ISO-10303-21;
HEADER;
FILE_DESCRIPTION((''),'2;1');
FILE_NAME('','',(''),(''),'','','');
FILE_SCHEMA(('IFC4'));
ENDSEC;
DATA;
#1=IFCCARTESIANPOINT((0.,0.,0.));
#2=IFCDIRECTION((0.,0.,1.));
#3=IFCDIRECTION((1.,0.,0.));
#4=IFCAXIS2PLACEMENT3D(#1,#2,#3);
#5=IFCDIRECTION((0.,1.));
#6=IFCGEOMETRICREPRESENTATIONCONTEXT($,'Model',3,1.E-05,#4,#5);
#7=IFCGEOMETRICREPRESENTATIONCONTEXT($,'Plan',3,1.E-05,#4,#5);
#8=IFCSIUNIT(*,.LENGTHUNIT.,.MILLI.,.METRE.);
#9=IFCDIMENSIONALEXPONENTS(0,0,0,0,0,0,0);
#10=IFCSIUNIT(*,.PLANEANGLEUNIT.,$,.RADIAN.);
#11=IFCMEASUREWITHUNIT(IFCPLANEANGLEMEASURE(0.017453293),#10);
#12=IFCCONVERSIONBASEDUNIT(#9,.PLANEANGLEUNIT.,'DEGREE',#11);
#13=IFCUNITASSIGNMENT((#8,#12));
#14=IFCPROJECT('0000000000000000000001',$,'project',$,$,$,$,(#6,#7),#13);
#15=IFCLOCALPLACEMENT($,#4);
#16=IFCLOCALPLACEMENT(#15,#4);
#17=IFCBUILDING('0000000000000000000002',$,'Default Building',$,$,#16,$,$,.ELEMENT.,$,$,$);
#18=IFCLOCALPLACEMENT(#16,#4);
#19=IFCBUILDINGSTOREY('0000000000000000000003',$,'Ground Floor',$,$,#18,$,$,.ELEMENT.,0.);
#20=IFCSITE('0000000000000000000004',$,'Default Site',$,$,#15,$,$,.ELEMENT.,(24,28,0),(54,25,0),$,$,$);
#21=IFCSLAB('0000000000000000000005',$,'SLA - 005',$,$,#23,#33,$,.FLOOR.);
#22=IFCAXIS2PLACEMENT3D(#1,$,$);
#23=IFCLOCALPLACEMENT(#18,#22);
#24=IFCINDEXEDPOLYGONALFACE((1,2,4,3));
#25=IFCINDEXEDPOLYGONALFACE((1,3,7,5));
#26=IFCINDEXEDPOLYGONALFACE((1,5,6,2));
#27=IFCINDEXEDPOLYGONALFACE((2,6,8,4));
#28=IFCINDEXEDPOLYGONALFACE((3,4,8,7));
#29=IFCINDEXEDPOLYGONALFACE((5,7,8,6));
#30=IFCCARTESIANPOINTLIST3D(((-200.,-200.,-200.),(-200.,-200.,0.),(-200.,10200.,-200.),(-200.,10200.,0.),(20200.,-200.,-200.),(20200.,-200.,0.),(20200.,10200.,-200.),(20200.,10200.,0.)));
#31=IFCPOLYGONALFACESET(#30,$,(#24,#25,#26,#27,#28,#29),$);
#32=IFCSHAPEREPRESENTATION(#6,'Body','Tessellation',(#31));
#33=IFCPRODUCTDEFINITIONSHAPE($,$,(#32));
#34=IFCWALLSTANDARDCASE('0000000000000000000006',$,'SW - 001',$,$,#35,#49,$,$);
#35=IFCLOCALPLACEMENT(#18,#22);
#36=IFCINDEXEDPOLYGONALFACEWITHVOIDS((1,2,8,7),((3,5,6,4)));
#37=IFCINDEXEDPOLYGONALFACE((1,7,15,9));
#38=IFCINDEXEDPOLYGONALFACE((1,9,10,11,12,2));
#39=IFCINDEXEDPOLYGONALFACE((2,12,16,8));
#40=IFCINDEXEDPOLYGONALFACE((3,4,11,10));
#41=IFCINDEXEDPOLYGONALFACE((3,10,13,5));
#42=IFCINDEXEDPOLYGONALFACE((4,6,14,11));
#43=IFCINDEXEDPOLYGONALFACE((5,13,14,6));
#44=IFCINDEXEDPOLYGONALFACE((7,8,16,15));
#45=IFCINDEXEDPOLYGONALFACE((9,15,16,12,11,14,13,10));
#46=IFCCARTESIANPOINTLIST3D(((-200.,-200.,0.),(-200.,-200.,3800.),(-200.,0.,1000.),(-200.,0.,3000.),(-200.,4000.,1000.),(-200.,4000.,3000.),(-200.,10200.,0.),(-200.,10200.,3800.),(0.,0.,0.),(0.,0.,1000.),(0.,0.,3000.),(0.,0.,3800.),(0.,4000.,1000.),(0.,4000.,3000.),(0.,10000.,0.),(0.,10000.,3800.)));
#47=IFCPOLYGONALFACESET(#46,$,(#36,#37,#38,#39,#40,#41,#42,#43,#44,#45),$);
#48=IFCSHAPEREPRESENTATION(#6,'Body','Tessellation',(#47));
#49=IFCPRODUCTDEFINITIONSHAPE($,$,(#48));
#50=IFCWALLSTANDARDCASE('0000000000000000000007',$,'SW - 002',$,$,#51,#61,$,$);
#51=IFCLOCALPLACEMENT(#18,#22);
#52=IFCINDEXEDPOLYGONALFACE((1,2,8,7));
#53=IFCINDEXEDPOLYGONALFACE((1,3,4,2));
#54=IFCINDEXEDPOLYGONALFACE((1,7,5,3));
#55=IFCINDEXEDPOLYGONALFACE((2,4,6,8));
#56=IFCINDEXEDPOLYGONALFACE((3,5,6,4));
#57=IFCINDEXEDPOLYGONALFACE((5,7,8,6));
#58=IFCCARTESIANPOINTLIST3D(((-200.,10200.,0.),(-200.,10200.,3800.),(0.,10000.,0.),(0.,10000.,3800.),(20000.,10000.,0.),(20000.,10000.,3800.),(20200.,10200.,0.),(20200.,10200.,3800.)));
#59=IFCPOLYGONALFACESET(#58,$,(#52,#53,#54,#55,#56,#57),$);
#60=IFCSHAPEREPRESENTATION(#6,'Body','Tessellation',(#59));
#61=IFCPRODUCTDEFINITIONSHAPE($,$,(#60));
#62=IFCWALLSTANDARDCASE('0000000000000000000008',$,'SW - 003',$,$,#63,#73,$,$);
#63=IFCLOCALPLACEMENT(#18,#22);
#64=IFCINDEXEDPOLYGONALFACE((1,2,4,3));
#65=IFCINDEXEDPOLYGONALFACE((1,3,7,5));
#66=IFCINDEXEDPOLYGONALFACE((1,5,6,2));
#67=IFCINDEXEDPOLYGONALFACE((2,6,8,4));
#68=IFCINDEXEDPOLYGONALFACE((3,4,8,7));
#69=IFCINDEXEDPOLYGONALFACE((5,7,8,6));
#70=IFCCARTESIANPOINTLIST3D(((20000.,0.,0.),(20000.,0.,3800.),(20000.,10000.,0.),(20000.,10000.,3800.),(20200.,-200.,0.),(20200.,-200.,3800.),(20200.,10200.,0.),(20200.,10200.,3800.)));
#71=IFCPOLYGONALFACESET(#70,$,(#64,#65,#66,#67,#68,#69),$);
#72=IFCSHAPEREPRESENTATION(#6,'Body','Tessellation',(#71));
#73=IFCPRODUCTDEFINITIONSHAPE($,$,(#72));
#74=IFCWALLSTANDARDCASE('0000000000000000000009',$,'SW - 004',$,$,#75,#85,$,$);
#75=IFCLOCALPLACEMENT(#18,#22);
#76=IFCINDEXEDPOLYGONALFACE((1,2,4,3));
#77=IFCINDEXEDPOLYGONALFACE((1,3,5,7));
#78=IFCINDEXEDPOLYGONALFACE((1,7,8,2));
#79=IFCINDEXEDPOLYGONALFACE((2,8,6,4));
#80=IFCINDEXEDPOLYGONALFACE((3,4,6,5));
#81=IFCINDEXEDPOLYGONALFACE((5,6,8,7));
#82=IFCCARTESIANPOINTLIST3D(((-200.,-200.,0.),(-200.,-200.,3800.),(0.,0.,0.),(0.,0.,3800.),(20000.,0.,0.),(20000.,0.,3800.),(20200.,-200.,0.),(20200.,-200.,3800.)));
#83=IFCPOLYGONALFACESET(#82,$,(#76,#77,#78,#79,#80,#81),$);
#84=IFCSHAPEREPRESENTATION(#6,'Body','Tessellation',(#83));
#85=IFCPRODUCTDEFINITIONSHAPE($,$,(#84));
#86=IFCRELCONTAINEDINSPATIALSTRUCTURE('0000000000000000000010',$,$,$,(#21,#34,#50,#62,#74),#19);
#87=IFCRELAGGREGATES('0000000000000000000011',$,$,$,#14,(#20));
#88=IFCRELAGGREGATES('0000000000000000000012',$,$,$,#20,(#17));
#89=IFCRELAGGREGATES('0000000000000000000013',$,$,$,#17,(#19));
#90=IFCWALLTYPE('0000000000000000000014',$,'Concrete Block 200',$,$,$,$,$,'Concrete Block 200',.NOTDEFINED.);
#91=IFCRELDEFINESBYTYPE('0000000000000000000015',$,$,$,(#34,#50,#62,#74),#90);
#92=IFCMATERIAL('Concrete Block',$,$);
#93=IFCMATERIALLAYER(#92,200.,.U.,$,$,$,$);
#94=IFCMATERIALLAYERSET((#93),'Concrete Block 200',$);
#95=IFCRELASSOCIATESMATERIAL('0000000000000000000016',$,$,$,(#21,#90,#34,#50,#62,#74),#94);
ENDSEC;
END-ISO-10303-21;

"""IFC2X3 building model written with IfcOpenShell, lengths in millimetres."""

from ifc_helpers import new_model, entity, si_unit, converted_unit, direction, frame, frame_2d, origin_with_axes, place, context, project, spatial, polyline, rectangle, outline, extrude, material, layer, layer_set, layer_usage, type_object, element, save


model = new_model("IFC2X3")

# Units and contexts
model_context = context("Model", 3, precision=1e-05, world=origin_with_axes(), true_north=direction((0.0, 1.0)))
plan_context = context("Plan", 3, precision=1e-05, world=origin_with_axes(), true_north=direction((0.0, 1.0)))
ifc_project = project(units=[si_unit("LENGTHUNIT", "METRE", prefix="MILLI"), converted_unit("PLANEANGLEUNIT", "DEGREE", entity("IfcPlaneAngleMeasure", 0.017453293), si_unit("PLANEANGLEUNIT", "RADIAN"), dimensions=[0, 0, 0, 0, 0, 0, 0])], contexts=[model_context, plan_context])

# Site, building, storey
site_placement = place(None, origin_with_axes())
site = spatial("IfcSite", under=ifc_project, at=site_placement, Name="Default Site", CompositionType="ELEMENT", RefLatitude=(24, 28, 0), RefLongitude=(54, 25, 0))
building_placement = place(site_placement, origin_with_axes())
building = spatial("IfcBuilding", under=site, at=building_placement, Name="Default Building", CompositionType="ELEMENT")
storey_placement = place(building_placement, origin_with_axes())
storey = spatial("IfcBuildingStorey", under=building, at=storey_placement, Name="Ground Floor", CompositionType="ELEMENT", Elevation=0.0)

# Slab
ifc_material = material(Name="Concrete Block")
ifc_layer = layer(ifc_material, 200.0, ventilated="UNKNOWN")
ifc_layer_set = layer_set([ifc_layer], Name="Concrete Block 200")
ifc_layer_usage_1 = layer_usage(ifc_layer_set, "AXIS3", "NEGATIVE", 200.0)
slab_placement = place(storey_placement, frame((-200.0, 10200.0, -200.0), z_axis=(0.0, 0.0, 1.0), x_axis=(1.0, 0.0, 0.0)))
element("IfcSlab", 1, at=slab_placement, inside=storey, material=ifc_layer_usage_1, Name="SLA - 005", PredefinedType="FLOOR", context=model_context, shape_type="SweptSolid", body=[
    extrude(outline(polyline([(0.0, 0.0), (20400.0, 0.0), (20400.0, -10400.0), (0.0, -10400.0), (0.0, 0.0)])), origin_with_axes(), (0.0, 0.0, 1.0), 200.0),
])

# Wall, opening
ifc_layer_usage_2 = layer_usage(ifc_layer_set, "AXIS2", "POSITIVE", 0.0)
wall_type = type_object("IfcWallType", Name="Concrete Block 200", ElementType="Concrete Block 200", PredefinedType="NOTDEFINED", material=ifc_layer_set)
wall_1_placement = place(storey_placement, frame((0.0, 0.0, 0.0), z_axis=(0.0, 0.0, 1.0), x_axis=(0.0, 1.0, 0.0)))
wall_1 = element("IfcWallStandardCase", 2, at=wall_1_placement, inside=storey, type_object=wall_type, material=ifc_layer_usage_2, Name="SW - 001", context=model_context, shape_type="SweptSolid", body=[
    extrude(outline(polyline([(0.0, 0.0), (10000.0, 0.0), (10200.0, 200.0), (-200.0, 200.0), (0.0, 0.0)])), origin_with_axes(), (0.0, 0.0, 1.0), 3800.0),
])
opening_placement = place(wall_1_placement, frame((2000.0, 0.0, 1000.0), z_axis=(0.0, 0.0, 1.0), x_axis=(1.0, 0.0, 0.0)))
element("IfcOpeningElement", 3, at=opening_placement, cuts=wall_1, ObjectType="Opening", context=model_context, shape_type="SweptSolid", body=[
    extrude(rectangle(XDim=4000.0, YDim=2000.0, at=frame_2d((0.0, 1000.0), x_axis=(-1.0, 0.0))), frame((0.0, 0.0, 0.0), z_axis=(0.0, 1.0, 0.0), x_axis=(-1.0, 0.0, 0.0)), (0.0, 0.0, 1.0), 200.0),
])

# Walls
ifc_layer_usage_3 = layer_usage(ifc_layer_set, "AXIS2", "POSITIVE", 0.0)
wall_2_placement = place(storey_placement, frame((0.0, 10000.0, 0.0), z_axis=(0.0, 0.0, 1.0), x_axis=(1.0, 0.0, 0.0)))
element("IfcWallStandardCase", 4, at=wall_2_placement, inside=storey, type_object=wall_type, material=ifc_layer_usage_3, Name="SW - 002", context=model_context, shape_type="SweptSolid", body=[
    extrude(outline(polyline([(0.0, 0.0), (20000.0, 0.0), (20200.0, 200.0), (-200.0, 200.0), (0.0, 0.0)])), origin_with_axes(), (0.0, 0.0, 1.0), 3800.0),
])
ifc_layer_usage_4 = layer_usage(ifc_layer_set, "AXIS2", "POSITIVE", 0.0)
wall_3_placement = place(storey_placement, frame((20000.0, 10000.0, 0.0), z_axis=(0.0, 0.0, 1.0), x_axis=(0.0, -1.0, 0.0)))
element("IfcWallStandardCase", 5, at=wall_3_placement, inside=storey, type_object=wall_type, material=ifc_layer_usage_4, Name="SW - 003", context=model_context, shape_type="SweptSolid", body=[
    extrude(outline(polyline([(0.0, 0.0), (10000.0, 0.0), (10200.0, 200.0), (-200.0, 200.0), (0.0, 0.0)])), origin_with_axes(), (0.0, 0.0, 1.0), 3800.0),
])
ifc_layer_usage_5 = layer_usage(ifc_layer_set, "AXIS2", "POSITIVE", 0.0)
wall_4_placement = place(storey_placement, frame((20000.0, 0.0, 0.0), z_axis=(0.0, 0.0, 1.0), x_axis=(-1.0, 0.0, 0.0)))
element("IfcWallStandardCase", 6, at=wall_4_placement, inside=storey, type_object=wall_type, material=ifc_layer_usage_5, Name="SW - 004", context=model_context, shape_type="SweptSolid", body=[
    extrude(outline(polyline([(0.0, 0.0), (20000.0, 0.0), (20200.0, 200.0), (-200.0, 200.0), (0.0, 0.0)])), origin_with_axes(), (0.0, 0.0, 1.0), 3800.0),
])

save(model, "model.ifc")
